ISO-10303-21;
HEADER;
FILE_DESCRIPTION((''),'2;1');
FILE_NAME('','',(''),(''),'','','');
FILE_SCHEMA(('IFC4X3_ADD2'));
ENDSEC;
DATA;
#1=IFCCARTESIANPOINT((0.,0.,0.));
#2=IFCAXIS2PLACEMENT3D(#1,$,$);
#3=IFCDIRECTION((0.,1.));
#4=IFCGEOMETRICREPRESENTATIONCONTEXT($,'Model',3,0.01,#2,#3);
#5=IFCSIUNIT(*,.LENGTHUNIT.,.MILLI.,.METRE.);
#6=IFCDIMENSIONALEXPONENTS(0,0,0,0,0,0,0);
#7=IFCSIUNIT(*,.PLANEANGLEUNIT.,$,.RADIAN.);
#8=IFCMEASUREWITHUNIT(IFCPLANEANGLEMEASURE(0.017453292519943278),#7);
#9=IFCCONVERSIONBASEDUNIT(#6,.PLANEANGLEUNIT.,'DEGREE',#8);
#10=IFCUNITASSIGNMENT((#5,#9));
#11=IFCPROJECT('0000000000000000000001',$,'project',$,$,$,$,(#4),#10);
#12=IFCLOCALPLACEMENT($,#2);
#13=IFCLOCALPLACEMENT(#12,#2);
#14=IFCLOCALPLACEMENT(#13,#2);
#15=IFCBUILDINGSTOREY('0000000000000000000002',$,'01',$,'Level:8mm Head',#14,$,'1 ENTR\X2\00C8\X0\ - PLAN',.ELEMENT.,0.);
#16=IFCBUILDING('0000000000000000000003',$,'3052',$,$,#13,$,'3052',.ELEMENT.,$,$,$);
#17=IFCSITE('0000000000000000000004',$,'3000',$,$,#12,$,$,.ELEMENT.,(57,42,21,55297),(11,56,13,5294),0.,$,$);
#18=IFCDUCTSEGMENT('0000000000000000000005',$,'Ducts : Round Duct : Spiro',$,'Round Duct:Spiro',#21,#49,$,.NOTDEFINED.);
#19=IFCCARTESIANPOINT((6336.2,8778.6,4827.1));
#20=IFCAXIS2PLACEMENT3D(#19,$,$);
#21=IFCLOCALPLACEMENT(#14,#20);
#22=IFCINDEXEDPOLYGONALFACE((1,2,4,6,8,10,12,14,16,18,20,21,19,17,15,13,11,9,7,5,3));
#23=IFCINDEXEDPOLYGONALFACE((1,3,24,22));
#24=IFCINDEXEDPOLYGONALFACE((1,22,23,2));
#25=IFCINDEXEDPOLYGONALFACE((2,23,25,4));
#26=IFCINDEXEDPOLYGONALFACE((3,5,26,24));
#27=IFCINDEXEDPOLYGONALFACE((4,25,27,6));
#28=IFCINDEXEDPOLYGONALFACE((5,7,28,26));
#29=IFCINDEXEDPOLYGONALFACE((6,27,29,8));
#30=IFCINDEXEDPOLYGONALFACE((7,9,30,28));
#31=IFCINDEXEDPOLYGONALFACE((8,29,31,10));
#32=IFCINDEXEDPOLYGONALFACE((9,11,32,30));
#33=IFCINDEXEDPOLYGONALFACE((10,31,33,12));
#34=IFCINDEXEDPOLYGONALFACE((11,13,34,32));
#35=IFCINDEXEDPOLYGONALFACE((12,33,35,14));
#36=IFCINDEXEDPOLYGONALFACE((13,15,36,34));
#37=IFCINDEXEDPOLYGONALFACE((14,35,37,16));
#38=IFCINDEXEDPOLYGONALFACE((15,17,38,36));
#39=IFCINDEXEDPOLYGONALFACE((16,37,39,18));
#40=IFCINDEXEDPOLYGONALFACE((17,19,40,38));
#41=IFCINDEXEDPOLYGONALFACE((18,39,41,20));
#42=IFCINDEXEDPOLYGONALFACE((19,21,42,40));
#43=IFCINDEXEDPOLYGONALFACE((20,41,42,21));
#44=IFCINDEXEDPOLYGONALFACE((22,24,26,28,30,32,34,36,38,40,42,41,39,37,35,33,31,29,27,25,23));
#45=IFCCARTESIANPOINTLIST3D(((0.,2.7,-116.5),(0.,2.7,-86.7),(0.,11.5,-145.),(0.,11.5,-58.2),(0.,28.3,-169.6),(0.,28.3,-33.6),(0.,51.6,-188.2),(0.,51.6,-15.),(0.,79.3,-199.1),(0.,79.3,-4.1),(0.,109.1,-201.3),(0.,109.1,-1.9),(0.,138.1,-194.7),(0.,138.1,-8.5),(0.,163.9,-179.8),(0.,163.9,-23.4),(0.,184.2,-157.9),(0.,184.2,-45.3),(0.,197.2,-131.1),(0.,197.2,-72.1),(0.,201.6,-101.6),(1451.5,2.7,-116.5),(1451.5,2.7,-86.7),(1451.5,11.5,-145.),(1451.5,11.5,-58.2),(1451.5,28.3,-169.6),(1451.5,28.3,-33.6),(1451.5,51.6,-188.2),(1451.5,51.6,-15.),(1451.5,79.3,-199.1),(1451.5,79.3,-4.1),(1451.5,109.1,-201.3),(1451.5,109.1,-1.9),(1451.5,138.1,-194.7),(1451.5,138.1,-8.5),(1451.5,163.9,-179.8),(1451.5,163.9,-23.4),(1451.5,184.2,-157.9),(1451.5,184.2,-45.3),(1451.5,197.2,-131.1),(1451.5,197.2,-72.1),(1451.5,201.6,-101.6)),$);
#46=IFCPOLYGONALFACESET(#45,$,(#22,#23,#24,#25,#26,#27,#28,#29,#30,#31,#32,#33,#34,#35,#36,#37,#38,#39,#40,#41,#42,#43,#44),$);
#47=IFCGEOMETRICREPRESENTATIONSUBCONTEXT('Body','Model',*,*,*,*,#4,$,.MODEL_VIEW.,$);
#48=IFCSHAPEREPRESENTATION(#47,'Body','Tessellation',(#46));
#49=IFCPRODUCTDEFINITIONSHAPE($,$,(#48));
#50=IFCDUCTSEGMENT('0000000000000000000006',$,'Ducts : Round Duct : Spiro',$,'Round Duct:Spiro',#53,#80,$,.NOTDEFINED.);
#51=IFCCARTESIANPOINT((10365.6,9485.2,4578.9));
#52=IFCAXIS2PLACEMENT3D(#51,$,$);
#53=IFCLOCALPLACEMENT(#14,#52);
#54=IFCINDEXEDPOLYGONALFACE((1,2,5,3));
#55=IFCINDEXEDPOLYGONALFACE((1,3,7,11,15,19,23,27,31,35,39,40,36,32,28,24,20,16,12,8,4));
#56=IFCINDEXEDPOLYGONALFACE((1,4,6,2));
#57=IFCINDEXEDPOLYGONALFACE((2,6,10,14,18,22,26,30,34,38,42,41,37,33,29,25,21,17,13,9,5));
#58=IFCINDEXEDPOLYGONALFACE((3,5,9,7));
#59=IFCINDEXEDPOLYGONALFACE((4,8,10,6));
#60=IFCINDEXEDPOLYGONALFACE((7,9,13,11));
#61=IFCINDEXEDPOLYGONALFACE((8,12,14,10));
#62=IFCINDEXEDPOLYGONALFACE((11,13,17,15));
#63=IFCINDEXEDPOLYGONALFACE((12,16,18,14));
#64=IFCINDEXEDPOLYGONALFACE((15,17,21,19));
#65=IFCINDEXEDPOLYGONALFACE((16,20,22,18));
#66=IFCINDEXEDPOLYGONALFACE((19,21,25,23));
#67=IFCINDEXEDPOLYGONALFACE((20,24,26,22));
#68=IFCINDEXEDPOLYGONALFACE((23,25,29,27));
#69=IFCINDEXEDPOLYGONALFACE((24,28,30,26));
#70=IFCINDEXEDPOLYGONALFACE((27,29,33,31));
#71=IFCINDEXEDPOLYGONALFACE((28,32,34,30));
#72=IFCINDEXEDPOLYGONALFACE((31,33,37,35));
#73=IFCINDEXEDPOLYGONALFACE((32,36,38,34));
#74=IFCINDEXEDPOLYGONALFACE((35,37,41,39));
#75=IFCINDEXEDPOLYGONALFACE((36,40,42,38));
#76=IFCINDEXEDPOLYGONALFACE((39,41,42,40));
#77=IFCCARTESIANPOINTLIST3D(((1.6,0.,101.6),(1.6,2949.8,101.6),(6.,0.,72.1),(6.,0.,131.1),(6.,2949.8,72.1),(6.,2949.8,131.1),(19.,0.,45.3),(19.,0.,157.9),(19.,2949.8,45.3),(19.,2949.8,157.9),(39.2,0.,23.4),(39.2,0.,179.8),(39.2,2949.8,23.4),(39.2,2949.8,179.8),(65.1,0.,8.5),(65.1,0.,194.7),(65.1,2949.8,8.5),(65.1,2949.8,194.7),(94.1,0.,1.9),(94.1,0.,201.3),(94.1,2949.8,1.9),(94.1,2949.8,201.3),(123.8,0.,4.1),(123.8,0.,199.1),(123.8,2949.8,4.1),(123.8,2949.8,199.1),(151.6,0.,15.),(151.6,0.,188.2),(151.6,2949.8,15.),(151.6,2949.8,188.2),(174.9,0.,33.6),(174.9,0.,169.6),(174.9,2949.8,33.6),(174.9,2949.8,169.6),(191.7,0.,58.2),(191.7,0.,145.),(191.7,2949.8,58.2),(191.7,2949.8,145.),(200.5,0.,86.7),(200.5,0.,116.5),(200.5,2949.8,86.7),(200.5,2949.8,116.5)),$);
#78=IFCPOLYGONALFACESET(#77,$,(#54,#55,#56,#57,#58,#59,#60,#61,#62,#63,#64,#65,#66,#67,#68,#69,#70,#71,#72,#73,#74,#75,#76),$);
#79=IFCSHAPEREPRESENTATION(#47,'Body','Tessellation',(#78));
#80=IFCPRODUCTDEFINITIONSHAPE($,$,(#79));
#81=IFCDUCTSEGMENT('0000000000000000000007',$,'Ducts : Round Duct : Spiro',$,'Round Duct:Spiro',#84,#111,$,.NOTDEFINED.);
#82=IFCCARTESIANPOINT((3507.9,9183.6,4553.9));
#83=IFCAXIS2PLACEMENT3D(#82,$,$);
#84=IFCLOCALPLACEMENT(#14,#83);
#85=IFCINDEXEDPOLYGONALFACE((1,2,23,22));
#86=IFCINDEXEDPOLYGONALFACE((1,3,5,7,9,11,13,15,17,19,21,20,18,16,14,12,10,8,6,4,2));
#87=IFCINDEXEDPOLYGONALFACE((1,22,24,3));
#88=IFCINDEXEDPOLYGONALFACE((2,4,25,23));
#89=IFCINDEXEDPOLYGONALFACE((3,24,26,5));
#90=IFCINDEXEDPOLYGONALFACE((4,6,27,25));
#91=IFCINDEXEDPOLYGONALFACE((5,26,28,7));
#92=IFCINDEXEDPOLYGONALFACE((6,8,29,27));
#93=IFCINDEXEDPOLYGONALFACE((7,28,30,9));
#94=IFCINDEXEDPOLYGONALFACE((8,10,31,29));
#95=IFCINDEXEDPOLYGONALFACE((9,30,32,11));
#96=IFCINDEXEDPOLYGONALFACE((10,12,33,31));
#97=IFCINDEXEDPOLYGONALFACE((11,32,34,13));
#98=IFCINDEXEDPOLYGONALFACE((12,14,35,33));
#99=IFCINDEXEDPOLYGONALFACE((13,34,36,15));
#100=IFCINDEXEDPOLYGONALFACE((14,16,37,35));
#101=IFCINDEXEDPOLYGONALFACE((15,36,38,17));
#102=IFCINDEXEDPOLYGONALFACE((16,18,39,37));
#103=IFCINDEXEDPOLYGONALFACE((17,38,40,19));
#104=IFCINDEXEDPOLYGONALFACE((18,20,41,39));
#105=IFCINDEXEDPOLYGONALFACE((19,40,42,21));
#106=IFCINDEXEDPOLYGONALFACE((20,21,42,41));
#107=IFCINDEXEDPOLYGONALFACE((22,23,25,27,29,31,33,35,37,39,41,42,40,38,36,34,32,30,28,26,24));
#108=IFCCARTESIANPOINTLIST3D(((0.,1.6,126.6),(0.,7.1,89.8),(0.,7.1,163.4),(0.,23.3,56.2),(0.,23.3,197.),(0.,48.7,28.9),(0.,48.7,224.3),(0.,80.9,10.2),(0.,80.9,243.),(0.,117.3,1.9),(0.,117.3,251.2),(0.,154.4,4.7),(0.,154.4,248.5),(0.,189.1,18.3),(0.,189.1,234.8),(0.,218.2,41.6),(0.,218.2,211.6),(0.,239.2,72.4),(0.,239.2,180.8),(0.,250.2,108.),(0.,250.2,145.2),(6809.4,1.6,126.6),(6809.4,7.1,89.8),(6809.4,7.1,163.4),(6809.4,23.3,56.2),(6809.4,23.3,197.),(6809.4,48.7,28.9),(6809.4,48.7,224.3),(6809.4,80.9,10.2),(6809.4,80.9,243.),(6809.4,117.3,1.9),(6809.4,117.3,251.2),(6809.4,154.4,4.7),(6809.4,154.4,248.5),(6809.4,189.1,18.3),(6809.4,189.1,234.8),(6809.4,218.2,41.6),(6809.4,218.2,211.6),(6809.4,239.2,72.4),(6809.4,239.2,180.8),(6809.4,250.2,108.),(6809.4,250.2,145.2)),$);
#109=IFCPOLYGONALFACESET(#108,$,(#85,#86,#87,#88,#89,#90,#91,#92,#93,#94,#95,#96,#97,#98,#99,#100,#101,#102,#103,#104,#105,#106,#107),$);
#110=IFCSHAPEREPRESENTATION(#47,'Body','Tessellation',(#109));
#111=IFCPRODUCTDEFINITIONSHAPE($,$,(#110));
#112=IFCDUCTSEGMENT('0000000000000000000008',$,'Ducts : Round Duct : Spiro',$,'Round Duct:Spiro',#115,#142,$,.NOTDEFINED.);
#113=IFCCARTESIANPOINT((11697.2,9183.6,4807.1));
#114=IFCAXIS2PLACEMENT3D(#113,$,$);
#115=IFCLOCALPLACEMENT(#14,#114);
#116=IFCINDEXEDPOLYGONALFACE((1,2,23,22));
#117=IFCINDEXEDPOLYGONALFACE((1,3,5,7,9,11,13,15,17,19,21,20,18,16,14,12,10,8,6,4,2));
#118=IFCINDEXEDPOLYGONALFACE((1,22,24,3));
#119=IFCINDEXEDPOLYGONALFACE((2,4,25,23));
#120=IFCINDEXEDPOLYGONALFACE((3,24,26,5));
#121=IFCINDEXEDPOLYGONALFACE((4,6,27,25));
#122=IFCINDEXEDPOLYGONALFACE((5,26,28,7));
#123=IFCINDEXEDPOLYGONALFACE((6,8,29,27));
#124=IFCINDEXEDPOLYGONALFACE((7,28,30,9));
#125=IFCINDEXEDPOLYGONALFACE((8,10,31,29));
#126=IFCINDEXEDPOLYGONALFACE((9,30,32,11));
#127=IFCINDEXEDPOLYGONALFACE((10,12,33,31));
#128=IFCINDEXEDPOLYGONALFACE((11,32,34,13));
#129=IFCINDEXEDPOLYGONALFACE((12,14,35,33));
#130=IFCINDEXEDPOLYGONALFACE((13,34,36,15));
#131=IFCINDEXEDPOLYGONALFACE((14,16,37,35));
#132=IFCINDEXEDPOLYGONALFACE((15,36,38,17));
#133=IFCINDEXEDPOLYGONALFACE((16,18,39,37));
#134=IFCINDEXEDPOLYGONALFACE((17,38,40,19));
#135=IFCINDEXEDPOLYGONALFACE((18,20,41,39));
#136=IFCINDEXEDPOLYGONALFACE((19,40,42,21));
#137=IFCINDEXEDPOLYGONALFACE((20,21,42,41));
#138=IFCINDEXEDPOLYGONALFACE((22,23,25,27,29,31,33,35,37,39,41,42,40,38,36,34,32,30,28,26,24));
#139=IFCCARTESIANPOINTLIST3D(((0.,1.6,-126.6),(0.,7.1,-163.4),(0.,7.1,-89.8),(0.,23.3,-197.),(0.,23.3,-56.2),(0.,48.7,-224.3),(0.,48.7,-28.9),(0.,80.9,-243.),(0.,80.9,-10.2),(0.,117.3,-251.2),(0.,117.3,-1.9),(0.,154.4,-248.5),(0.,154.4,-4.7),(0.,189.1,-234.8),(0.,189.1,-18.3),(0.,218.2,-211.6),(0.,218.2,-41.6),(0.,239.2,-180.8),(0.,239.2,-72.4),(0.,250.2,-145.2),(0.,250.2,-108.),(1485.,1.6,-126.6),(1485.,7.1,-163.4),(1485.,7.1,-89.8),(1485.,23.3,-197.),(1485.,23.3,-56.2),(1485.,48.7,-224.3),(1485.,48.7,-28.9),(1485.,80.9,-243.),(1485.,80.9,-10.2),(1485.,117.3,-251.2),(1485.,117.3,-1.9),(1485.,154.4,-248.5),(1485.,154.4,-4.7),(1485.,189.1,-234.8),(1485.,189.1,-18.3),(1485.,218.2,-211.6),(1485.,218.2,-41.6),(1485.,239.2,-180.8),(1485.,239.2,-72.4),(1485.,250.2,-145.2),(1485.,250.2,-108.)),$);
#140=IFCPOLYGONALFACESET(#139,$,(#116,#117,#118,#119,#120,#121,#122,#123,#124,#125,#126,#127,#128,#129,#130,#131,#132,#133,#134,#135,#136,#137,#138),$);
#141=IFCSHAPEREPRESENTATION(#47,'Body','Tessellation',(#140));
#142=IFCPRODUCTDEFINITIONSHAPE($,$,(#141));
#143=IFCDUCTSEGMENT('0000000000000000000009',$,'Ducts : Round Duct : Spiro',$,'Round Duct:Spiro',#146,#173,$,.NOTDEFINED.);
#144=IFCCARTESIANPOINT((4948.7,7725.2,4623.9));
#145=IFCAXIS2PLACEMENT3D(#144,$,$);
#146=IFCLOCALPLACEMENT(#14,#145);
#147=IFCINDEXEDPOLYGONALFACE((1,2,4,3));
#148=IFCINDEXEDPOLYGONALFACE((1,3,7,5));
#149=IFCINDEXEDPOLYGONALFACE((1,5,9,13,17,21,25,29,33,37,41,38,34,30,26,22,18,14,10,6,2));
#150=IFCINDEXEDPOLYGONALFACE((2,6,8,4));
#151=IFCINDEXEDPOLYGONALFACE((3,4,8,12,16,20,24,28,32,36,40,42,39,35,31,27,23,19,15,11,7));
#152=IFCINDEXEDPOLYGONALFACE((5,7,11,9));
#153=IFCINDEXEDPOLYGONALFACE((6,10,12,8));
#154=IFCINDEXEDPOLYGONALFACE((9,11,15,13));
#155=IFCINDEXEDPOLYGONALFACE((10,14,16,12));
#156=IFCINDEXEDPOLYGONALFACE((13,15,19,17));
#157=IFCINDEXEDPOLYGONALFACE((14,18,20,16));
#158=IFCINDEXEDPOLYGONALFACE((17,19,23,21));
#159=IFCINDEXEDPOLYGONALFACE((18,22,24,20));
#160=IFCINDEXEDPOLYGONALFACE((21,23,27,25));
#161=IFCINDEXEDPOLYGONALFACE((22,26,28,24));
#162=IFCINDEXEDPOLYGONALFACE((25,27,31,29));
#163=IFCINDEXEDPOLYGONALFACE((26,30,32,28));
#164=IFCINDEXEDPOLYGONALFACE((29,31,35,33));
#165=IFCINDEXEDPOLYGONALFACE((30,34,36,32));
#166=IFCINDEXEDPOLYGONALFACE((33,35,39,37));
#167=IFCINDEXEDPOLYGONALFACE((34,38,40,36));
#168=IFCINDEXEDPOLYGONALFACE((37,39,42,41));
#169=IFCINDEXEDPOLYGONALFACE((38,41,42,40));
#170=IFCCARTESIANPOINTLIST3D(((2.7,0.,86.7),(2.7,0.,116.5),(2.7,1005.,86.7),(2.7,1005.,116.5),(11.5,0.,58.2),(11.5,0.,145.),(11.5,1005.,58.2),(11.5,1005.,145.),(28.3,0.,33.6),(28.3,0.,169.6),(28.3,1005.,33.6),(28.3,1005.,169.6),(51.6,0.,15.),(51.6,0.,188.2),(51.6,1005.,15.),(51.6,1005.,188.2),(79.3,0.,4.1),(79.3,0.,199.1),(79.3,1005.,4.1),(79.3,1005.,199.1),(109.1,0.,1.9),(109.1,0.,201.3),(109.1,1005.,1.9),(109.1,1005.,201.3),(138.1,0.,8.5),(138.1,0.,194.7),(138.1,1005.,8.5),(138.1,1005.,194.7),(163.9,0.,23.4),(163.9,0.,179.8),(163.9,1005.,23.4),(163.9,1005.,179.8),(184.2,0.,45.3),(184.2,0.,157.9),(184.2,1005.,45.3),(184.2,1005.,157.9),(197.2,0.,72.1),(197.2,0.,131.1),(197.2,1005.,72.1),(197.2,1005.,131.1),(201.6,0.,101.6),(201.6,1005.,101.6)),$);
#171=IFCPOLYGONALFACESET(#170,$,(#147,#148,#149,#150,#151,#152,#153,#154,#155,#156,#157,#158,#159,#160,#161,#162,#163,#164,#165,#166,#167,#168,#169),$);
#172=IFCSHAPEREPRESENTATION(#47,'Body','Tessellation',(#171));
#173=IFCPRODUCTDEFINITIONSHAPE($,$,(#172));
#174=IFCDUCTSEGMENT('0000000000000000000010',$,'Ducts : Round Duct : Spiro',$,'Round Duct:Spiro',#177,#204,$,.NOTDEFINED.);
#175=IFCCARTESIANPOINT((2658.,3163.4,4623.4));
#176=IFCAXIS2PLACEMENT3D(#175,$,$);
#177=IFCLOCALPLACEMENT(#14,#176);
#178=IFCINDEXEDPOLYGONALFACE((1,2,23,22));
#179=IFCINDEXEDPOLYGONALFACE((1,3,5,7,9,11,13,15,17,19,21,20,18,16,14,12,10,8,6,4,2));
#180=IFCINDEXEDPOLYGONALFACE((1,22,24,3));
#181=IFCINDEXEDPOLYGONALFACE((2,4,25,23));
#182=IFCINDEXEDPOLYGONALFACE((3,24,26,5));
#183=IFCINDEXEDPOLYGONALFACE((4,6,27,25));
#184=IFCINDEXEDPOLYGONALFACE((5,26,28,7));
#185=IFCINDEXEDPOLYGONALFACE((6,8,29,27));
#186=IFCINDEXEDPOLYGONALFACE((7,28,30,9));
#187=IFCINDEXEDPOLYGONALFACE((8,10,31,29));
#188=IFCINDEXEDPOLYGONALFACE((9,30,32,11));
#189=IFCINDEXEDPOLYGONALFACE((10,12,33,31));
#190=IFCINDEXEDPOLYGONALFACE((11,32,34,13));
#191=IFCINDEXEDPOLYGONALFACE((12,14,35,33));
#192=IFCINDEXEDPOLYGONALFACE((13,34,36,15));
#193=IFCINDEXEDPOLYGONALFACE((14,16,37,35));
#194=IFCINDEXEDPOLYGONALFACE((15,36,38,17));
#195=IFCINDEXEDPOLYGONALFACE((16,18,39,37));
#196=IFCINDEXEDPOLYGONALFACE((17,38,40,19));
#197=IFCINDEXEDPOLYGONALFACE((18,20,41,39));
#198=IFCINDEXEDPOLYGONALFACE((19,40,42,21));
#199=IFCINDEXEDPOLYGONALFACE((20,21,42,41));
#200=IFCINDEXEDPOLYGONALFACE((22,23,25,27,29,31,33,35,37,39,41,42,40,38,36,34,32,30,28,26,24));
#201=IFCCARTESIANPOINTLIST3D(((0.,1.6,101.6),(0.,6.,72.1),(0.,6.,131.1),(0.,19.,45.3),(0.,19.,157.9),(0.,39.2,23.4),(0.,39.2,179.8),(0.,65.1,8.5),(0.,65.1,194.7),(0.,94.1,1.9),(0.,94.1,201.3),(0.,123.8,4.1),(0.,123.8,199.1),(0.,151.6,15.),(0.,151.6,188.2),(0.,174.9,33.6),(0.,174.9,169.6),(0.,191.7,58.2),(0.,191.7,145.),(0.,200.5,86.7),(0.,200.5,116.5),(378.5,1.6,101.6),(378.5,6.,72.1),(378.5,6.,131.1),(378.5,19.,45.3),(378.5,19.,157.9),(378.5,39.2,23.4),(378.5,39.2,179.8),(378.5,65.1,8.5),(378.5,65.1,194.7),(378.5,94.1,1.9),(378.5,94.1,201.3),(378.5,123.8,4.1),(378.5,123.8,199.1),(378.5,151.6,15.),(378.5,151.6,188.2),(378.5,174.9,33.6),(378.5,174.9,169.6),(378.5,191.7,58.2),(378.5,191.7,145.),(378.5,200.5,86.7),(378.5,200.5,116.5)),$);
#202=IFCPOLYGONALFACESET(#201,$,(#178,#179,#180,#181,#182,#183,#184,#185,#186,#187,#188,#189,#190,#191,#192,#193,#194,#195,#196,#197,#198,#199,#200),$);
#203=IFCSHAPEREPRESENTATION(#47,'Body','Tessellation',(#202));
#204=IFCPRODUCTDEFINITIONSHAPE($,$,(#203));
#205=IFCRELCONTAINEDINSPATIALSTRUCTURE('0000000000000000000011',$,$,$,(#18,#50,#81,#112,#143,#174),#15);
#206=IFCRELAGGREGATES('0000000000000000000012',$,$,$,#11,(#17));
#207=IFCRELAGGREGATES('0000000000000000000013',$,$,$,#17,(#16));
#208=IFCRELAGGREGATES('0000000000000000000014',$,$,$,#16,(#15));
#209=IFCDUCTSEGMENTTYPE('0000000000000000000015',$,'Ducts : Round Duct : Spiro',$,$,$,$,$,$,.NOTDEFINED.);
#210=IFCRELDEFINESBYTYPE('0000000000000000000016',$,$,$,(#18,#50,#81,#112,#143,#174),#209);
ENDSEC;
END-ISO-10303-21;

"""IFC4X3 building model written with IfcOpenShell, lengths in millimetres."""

from ifc_helpers import new_model, entity, si_unit, converted_unit, direction, frame, frame_2d, origin, origin_2d_with_axis, place, context, subcontext, project, spatial, circle, extrude, type_object, element, save


model = new_model("IFC4X3")

# Units and contexts
model_context = context("Model", 3, precision=0.01, world=origin(), true_north=direction((0.0, 1.0)))
body_context = subcontext(model_context, "Body", "Model", "MODEL_VIEW")
ifc_project = project(units=[si_unit("LENGTHUNIT", "METRE", prefix="MILLI"), converted_unit("PLANEANGLEUNIT", "DEGREE", entity("IfcPlaneAngleMeasure", 0.017453292519943278), si_unit("PLANEANGLEUNIT", "RADIAN"), dimensions=[0, 0, 0, 0, 0, 0, 0])], contexts=[model_context])

# Site, building, storey
site_placement = place(None, origin())
site = spatial("IfcSite", under=ifc_project, at=site_placement, Name="3000", CompositionType="ELEMENT", RefLatitude=(57, 42, 21, 55297), RefLongitude=(11, 56, 13, 5294), RefElevation=0.0)
building_placement = place(site_placement, origin())
building = spatial("IfcBuilding", under=site, at=building_placement, Name="3052", LongName="3052", CompositionType="ELEMENT")
storey_placement = place(building_placement, origin())
storey = spatial("IfcBuildingStorey", under=building, at=storey_placement, Name="01", ObjectType="Level:8mm Head", LongName="1 ENTRÈ - PLAN", CompositionType="ELEMENT", Elevation=0.0)

# Duct segments
duct_segment_type = type_object("IfcDuctSegmentType", Name="Ducts : Round Duct : Spiro", PredefinedType="NOTDEFINED")
duct_segment_1_placement = place(storey_placement, frame((6336.2, 8778.6, 4827.1)))
element("IfcDuctSegment", 1, at=duct_segment_1_placement, inside=storey, type_object=duct_segment_type, Name="Ducts : Round Duct : Spiro", ObjectType="Round Duct:Spiro", PredefinedType="NOTDEFINED", context=body_context, shape_type="SweptSolid", body=[
    extrude(circle(Radius=100.0, at=frame_2d((0.0, 0.0), x_axis=(1.0, 0.0))), frame((0.0, 101.6, -101.6), z_axis=(1.0, 0.0, 0.0), x_axis=(0.0, 1.0, 0.0)), (0.0, 0.0, 1.0), 1451.5),
])
duct_segment_2_placement = place(storey_placement, frame((10365.6, 9485.2, 4578.9)))
element("IfcDuctSegment", 2, at=duct_segment_2_placement, inside=storey, type_object=duct_segment_type, Name="Ducts : Round Duct : Spiro", ObjectType="Round Duct:Spiro", PredefinedType="NOTDEFINED", context=body_context, shape_type="SweptSolid", body=[
    extrude(circle(Radius=100.0, at=origin_2d_with_axis()), frame((101.6, 0.0, 101.6), z_axis=(0.0, 1.0, 0.0), x_axis=(-1.0, 0.0, 0.0)), (0.0, 0.0, 1.0), 2949.8),
])
duct_segment_3_placement = place(storey_placement, frame((3507.9, 9183.6, 4553.9)))
element("IfcDuctSegment", 3, at=duct_segment_3_placement, inside=storey, type_object=duct_segment_type, Name="Ducts : Round Duct : Spiro", ObjectType="Round Duct:Spiro", PredefinedType="NOTDEFINED", context=body_context, shape_type="SweptSolid", body=[
    extrude(circle(Radius=125.0, at=frame_2d((0.0, 0.0), x_axis=(1.0, 0.0))), frame((0.0, 126.6, 126.6), z_axis=(1.0, 0.0, 0.0), x_axis=(0.0, -1.0, 0.0)), (0.0, 0.0, 1.0), 6809.4),
])
duct_segment_4_placement = place(storey_placement, frame((11697.2, 9183.6, 4807.1)))
element("IfcDuctSegment", 4, at=duct_segment_4_placement, inside=storey, type_object=duct_segment_type, Name="Ducts : Round Duct : Spiro", ObjectType="Round Duct:Spiro", PredefinedType="NOTDEFINED", context=body_context, shape_type="SweptSolid", body=[
    extrude(circle(Radius=125.0, at=frame_2d((0.0, 0.0), x_axis=(1.0, 0.0))), frame((0.0, 126.6, -126.6), z_axis=(1.0, 0.0, 0.0), x_axis=(0.0, -1.0, 0.0)), (0.0, 0.0, 1.0), 1485.0),
])
duct_segment_5_placement = place(storey_placement, frame((4948.7, 7725.2, 4623.9)))
element("IfcDuctSegment", 5, at=duct_segment_5_placement, inside=storey, type_object=duct_segment_type, Name="Ducts : Round Duct : Spiro", ObjectType="Round Duct:Spiro", PredefinedType="NOTDEFINED", context=body_context, shape_type="SweptSolid", body=[
    extrude(circle(Radius=100.0, at=origin_2d_with_axis()), frame((101.6, 0.0, 101.6), z_axis=(0.0, 1.0, 0.0), x_axis=(1.0, 0.0, 0.0)), (0.0, 0.0, 1.0), 1005.0),
])
duct_segment_6_placement = place(storey_placement, frame((2658.0, 3163.4, 4623.4)))
element("IfcDuctSegment", 6, at=duct_segment_6_placement, inside=storey, type_object=duct_segment_type, Name="Ducts : Round Duct : Spiro", ObjectType="Round Duct:Spiro", PredefinedType="NOTDEFINED", context=body_context, shape_type="SweptSolid", body=[
    extrude(circle(Radius=100.0, at=frame_2d((0.0, 0.0), x_axis=(1.0, 0.0))), frame((0.0, 101.6, 101.6), z_axis=(1.0, 0.0, 0.0), x_axis=(0.0, -1.0, 0.0)), (0.0, 0.0, 1.0), 378.5),
])

save(model, "model.ifc")
